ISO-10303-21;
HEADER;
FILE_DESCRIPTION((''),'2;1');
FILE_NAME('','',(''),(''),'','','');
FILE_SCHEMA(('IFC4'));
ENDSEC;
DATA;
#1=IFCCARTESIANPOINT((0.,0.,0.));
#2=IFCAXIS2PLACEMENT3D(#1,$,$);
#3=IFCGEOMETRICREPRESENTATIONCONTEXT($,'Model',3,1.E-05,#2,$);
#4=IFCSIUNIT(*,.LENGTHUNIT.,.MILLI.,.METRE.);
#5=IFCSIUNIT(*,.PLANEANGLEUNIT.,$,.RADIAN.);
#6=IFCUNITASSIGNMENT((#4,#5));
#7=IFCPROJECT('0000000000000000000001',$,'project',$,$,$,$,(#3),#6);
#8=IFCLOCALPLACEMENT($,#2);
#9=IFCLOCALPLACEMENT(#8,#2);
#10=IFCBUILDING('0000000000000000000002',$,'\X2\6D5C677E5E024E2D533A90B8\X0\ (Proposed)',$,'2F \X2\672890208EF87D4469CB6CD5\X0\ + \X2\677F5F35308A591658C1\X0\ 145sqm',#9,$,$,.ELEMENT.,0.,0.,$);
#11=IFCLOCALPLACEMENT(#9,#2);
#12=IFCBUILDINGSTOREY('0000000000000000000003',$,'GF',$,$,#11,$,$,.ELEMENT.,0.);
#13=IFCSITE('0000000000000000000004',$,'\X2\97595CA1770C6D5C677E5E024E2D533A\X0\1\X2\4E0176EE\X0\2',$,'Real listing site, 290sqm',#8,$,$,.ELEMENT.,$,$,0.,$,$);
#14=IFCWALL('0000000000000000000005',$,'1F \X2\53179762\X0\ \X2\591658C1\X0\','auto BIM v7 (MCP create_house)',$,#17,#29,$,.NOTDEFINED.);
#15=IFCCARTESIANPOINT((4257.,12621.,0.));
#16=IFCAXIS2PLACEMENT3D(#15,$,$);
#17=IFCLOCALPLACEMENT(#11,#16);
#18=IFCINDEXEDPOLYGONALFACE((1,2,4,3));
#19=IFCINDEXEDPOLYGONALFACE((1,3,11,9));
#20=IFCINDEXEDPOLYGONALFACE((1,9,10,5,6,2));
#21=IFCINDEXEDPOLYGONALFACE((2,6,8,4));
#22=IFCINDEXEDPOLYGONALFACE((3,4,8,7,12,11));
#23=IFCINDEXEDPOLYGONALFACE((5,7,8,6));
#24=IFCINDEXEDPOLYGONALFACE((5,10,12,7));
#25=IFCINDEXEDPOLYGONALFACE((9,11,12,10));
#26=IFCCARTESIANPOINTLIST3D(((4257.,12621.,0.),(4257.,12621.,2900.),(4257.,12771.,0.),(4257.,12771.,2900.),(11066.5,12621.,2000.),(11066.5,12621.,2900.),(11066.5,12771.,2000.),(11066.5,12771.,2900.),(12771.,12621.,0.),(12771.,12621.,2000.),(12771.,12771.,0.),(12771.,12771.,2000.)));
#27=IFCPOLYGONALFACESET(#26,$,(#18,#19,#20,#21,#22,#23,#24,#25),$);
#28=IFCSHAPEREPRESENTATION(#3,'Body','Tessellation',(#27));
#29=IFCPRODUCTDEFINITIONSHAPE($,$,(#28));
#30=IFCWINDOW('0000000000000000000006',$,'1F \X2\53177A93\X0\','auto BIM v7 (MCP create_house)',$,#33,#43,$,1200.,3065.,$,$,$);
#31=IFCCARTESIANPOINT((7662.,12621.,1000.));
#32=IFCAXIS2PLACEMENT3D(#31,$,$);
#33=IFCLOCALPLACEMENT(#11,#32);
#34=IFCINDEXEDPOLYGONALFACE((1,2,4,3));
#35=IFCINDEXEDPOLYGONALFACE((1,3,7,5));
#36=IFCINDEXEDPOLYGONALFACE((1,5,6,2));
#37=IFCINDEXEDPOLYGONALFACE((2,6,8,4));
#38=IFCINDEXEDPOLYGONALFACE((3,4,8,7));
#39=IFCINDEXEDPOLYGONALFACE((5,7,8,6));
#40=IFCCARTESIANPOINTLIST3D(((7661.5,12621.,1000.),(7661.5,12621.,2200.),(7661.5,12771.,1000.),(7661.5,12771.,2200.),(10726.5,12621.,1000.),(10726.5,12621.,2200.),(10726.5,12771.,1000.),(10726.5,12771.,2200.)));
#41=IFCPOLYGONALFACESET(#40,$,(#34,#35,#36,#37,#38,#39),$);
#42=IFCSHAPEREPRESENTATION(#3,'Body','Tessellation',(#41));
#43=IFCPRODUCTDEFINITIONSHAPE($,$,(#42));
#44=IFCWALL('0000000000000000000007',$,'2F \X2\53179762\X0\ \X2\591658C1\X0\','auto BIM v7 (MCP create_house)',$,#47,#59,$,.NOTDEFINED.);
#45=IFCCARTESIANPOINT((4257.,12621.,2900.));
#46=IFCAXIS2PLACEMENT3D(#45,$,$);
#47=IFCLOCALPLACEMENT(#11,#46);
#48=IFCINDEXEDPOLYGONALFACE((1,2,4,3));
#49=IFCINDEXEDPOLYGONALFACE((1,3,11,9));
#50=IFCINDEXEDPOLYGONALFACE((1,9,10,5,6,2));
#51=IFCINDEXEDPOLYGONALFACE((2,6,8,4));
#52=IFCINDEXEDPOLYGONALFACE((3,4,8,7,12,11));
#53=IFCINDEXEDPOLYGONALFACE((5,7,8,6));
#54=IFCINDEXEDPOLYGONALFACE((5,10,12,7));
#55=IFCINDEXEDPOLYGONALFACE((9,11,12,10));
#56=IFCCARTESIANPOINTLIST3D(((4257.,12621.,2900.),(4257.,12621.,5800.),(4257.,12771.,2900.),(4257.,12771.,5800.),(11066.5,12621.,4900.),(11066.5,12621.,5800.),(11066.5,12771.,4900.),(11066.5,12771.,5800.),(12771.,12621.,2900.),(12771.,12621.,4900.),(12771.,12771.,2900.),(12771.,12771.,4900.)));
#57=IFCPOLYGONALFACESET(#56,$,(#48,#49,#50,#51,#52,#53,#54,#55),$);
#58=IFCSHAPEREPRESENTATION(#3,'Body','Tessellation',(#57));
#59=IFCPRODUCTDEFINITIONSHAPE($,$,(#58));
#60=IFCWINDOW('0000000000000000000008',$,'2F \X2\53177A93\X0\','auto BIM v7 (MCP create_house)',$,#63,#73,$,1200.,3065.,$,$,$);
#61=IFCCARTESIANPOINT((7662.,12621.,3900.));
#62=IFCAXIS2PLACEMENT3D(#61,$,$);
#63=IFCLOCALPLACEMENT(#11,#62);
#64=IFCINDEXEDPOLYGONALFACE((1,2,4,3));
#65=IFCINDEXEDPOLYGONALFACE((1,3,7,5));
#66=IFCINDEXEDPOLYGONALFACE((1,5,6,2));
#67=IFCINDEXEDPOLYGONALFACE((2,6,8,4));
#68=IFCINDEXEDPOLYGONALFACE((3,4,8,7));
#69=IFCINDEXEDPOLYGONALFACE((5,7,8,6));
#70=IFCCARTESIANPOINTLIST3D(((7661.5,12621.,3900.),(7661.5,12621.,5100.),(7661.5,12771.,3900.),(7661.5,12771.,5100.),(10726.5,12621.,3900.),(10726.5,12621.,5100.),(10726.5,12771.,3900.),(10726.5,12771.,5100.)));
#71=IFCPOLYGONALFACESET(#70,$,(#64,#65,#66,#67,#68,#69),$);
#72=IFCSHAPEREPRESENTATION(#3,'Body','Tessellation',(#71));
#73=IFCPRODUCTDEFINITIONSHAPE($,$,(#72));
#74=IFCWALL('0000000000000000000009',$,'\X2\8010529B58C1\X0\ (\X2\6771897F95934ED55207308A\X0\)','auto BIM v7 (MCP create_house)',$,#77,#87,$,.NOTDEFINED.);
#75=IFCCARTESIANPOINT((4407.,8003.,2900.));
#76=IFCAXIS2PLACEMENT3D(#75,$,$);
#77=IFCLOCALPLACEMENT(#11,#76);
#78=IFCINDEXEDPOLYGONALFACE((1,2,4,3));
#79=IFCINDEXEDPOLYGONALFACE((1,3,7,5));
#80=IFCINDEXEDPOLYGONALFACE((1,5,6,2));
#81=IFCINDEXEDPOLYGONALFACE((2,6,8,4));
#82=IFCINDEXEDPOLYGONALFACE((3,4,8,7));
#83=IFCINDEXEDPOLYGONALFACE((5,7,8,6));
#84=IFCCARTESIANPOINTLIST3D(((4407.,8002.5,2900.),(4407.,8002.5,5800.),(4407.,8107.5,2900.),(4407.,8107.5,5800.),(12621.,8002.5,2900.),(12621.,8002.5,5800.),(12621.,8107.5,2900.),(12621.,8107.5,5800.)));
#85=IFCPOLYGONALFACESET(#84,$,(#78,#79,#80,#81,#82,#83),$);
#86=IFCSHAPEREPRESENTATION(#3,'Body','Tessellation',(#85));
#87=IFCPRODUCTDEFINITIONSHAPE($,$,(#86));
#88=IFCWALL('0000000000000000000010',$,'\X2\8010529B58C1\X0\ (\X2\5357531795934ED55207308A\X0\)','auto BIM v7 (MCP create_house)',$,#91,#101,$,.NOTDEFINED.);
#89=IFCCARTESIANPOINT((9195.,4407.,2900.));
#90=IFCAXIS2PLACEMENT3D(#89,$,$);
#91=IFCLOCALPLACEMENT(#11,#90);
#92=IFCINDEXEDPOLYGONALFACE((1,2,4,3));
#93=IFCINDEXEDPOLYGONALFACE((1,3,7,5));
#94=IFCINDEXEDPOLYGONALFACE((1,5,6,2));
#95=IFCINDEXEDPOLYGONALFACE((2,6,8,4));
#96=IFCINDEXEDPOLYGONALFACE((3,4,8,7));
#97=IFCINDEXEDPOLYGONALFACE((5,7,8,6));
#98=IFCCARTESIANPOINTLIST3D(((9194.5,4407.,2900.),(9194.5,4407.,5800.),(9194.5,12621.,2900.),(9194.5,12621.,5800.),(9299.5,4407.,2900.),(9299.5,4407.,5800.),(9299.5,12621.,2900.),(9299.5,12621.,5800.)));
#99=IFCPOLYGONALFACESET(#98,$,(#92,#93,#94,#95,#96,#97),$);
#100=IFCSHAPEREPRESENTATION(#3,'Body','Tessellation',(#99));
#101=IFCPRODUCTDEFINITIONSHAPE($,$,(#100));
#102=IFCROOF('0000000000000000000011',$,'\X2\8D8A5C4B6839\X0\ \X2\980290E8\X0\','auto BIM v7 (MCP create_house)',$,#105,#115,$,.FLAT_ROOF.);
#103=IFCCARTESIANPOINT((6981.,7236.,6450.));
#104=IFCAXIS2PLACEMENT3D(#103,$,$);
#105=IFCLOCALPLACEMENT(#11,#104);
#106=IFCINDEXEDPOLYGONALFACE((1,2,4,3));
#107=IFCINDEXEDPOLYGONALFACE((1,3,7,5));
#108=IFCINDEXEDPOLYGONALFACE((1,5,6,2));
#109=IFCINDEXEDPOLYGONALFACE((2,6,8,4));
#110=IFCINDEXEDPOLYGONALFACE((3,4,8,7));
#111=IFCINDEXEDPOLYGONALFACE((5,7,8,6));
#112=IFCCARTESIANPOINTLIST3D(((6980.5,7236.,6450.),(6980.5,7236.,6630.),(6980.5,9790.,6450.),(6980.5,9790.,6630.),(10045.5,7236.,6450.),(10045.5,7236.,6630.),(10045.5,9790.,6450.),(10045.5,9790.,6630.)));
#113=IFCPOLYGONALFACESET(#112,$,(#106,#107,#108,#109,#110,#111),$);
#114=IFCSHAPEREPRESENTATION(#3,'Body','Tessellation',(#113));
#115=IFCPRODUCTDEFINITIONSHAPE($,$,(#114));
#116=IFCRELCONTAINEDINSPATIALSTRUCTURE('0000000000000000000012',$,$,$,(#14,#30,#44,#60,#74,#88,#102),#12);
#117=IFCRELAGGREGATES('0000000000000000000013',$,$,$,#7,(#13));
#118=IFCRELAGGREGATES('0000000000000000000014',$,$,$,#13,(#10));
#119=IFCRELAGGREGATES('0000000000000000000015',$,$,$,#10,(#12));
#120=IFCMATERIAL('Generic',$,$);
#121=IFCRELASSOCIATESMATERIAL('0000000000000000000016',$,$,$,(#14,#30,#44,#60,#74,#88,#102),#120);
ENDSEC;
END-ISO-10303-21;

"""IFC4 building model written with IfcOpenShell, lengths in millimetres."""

from ifc_helpers import new_model, si_unit, frame, frame_2d, origin, place, context, project, spatial, rectangle, extrude, material, element, fill, save


model = new_model("IFC4")

# Units and contexts
model_context = context("Model", 3, precision=1e-05, world=origin())
ifc_project = project(units=[si_unit("LENGTHUNIT", "METRE", prefix="MILLI"), si_unit("PLANEANGLEUNIT", "RADIAN")], contexts=[model_context])

# Site, building, storey
site_placement = place(None, origin())
site = spatial("IfcSite", under=ifc_project, at=site_placement, Name="静岡県浜松市中区1丁目2", ObjectType="Real listing site, 290sqm", CompositionType="ELEMENT", RefElevation=0.0)
building_placement = place(site_placement, origin())
building = spatial("IfcBuilding", under=site, at=building_placement, Name="浜松市中区邸 (Proposed)", ObjectType="2F 木造軸組構法 + 板張り外壁 145sqm", CompositionType="ELEMENT", ElevationOfRefHeight=0.0, ElevationOfTerrain=0.0)
storey_placement = place(building_placement, origin())
storey = spatial("IfcBuildingStorey", under=building, at=storey_placement, Name="GF", CompositionType="ELEMENT", Elevation=0.0)

# Wall, opening, window
ifc_material = material(Name="Generic")
wall_1_placement = place(storey_placement, frame((4257.0, 12621.0, 0.0)))
wall_1 = element("IfcWall", 1, at=wall_1_placement, inside=storey, material=ifc_material, Name="1F 北面 外壁", Description="auto BIM v7 (MCP create_house)", PredefinedType="NOTDEFINED", context=model_context, shape_type="SweptSolid", body=[
    extrude(rectangle(XDim=8514.0, YDim=150.0, at=frame_2d((4257.0, 75.0))), frame((4257.0, 12621.0, 0.0)), (0.0, 0.0, 1.0), 2900.0),
])
opening_1_placement = place(storey_placement, frame((7662.0, 12621.0, 1000.0)))
opening_1 = element("IfcOpeningElement", 2, at=opening_1_placement, cuts=wall_1, PredefinedType="NOTDEFINED", context=model_context, shape_type="SweptSolid", body=[
    extrude(rectangle(XDim=3065.0, YDim=150.0, at=frame_2d((1532.0, 75.0))), frame((7662.0, 12621.0, 1000.0)), (0.0, 0.0, 1.0), 1200.0),
])
window_1_placement = place(storey_placement, frame((7662.0, 12621.0, 1000.0)))
window_1 = element("IfcWindow", 3, at=window_1_placement, inside=storey, material=ifc_material, Name="1F 北窓", Description="auto BIM v7 (MCP create_house)", OverallHeight=1200.0, OverallWidth=3065.0, context=model_context, shape_type="SweptSolid", body=[
    extrude(rectangle(XDim=3065.0, YDim=150.0, at=frame_2d((1532.0, 75.0))), frame((7662.0, 12621.0, 1000.0)), (0.0, 0.0, 1.0), 1200.0),
])
fill(opening_1, window_1)

# Wall, opening, window
wall_2_placement = place(storey_placement, frame((4257.0, 12621.0, 2900.0)))
wall_2 = element("IfcWall", 4, at=wall_2_placement, inside=storey, material=ifc_material, Name="2F 北面 外壁", Description="auto BIM v7 (MCP create_house)", PredefinedType="NOTDEFINED", context=model_context, shape_type="SweptSolid", body=[
    extrude(rectangle(XDim=8514.0, YDim=150.0, at=frame_2d((4257.0, 75.0))), frame((4257.0, 12621.0, 2900.0)), (0.0, 0.0, 1.0), 2900.0),
])
opening_2_placement = place(storey_placement, frame((7662.0, 12621.0, 3900.0)))
opening_2 = element("IfcOpeningElement", 5, at=opening_2_placement, cuts=wall_2, PredefinedType="NOTDEFINED", context=model_context, shape_type="SweptSolid", body=[
    extrude(rectangle(XDim=3065.0, YDim=150.0, at=frame_2d((1532.0, 75.0))), frame((7662.0, 12621.0, 3900.0)), (0.0, 0.0, 1.0), 1200.0),
])
window_2_placement = place(storey_placement, frame((7662.0, 12621.0, 3900.0)))
window_2 = element("IfcWindow", 6, at=window_2_placement, inside=storey, material=ifc_material, Name="2F 北窓", Description="auto BIM v7 (MCP create_house)", OverallHeight=1200.0, OverallWidth=3065.0, context=model_context, shape_type="SweptSolid", body=[
    extrude(rectangle(XDim=3065.0, YDim=150.0, at=frame_2d((1532.0, 75.0))), frame((7662.0, 12621.0, 3900.0)), (0.0, 0.0, 1.0), 1200.0),
])
fill(opening_2, window_2)

# Walls
wall_3_placement = place(storey_placement, frame((4407.0, 8003.0, 2900.0)))
element("IfcWall", 7, at=wall_3_placement, inside=storey, material=ifc_material, Name="耐力壁 (東西間仕切り)", Description="auto BIM v7 (MCP create_house)", PredefinedType="NOTDEFINED", context=model_context, shape_type="SweptSolid", body=[
    extrude(rectangle(XDim=8214.0, YDim=105.0, at=frame_2d((4107.0, 52.0))), frame((4407.0, 8003.0, 2900.0)), (0.0, 0.0, 1.0), 2900.0),
])
wall_4_placement = place(storey_placement, frame((9195.0, 4407.0, 2900.0)))
element("IfcWall", 8, at=wall_4_placement, inside=storey, material=ifc_material, Name="耐力壁 (南北間仕切り)", Description="auto BIM v7 (MCP create_house)", PredefinedType="NOTDEFINED", context=model_context, shape_type="SweptSolid", body=[
    extrude(rectangle(XDim=105.0, YDim=8214.0, at=frame_2d((52.0, 4107.0))), frame((9195.0, 4407.0, 2900.0)), (0.0, 0.0, 1.0), 2900.0),
])

# Roof
roof_placement = place(storey_placement, frame((6981.0, 7236.0, 6450.0)))
element("IfcRoof", 9, at=roof_placement, inside=storey, material=ifc_material, Name="越屋根 頂部", Description="auto BIM v7 (MCP create_house)", PredefinedType="FLAT_ROOF", context=model_context, shape_type="SweptSolid", body=[
    extrude(rectangle(XDim=3065.0, YDim=2554.0, at=frame_2d((1532.0, 1277.0))), frame((6981.0, 7236.0, 6450.0)), (0.0, 0.0, 1.0), 180.0),
])

save(model, "model.ifc")
